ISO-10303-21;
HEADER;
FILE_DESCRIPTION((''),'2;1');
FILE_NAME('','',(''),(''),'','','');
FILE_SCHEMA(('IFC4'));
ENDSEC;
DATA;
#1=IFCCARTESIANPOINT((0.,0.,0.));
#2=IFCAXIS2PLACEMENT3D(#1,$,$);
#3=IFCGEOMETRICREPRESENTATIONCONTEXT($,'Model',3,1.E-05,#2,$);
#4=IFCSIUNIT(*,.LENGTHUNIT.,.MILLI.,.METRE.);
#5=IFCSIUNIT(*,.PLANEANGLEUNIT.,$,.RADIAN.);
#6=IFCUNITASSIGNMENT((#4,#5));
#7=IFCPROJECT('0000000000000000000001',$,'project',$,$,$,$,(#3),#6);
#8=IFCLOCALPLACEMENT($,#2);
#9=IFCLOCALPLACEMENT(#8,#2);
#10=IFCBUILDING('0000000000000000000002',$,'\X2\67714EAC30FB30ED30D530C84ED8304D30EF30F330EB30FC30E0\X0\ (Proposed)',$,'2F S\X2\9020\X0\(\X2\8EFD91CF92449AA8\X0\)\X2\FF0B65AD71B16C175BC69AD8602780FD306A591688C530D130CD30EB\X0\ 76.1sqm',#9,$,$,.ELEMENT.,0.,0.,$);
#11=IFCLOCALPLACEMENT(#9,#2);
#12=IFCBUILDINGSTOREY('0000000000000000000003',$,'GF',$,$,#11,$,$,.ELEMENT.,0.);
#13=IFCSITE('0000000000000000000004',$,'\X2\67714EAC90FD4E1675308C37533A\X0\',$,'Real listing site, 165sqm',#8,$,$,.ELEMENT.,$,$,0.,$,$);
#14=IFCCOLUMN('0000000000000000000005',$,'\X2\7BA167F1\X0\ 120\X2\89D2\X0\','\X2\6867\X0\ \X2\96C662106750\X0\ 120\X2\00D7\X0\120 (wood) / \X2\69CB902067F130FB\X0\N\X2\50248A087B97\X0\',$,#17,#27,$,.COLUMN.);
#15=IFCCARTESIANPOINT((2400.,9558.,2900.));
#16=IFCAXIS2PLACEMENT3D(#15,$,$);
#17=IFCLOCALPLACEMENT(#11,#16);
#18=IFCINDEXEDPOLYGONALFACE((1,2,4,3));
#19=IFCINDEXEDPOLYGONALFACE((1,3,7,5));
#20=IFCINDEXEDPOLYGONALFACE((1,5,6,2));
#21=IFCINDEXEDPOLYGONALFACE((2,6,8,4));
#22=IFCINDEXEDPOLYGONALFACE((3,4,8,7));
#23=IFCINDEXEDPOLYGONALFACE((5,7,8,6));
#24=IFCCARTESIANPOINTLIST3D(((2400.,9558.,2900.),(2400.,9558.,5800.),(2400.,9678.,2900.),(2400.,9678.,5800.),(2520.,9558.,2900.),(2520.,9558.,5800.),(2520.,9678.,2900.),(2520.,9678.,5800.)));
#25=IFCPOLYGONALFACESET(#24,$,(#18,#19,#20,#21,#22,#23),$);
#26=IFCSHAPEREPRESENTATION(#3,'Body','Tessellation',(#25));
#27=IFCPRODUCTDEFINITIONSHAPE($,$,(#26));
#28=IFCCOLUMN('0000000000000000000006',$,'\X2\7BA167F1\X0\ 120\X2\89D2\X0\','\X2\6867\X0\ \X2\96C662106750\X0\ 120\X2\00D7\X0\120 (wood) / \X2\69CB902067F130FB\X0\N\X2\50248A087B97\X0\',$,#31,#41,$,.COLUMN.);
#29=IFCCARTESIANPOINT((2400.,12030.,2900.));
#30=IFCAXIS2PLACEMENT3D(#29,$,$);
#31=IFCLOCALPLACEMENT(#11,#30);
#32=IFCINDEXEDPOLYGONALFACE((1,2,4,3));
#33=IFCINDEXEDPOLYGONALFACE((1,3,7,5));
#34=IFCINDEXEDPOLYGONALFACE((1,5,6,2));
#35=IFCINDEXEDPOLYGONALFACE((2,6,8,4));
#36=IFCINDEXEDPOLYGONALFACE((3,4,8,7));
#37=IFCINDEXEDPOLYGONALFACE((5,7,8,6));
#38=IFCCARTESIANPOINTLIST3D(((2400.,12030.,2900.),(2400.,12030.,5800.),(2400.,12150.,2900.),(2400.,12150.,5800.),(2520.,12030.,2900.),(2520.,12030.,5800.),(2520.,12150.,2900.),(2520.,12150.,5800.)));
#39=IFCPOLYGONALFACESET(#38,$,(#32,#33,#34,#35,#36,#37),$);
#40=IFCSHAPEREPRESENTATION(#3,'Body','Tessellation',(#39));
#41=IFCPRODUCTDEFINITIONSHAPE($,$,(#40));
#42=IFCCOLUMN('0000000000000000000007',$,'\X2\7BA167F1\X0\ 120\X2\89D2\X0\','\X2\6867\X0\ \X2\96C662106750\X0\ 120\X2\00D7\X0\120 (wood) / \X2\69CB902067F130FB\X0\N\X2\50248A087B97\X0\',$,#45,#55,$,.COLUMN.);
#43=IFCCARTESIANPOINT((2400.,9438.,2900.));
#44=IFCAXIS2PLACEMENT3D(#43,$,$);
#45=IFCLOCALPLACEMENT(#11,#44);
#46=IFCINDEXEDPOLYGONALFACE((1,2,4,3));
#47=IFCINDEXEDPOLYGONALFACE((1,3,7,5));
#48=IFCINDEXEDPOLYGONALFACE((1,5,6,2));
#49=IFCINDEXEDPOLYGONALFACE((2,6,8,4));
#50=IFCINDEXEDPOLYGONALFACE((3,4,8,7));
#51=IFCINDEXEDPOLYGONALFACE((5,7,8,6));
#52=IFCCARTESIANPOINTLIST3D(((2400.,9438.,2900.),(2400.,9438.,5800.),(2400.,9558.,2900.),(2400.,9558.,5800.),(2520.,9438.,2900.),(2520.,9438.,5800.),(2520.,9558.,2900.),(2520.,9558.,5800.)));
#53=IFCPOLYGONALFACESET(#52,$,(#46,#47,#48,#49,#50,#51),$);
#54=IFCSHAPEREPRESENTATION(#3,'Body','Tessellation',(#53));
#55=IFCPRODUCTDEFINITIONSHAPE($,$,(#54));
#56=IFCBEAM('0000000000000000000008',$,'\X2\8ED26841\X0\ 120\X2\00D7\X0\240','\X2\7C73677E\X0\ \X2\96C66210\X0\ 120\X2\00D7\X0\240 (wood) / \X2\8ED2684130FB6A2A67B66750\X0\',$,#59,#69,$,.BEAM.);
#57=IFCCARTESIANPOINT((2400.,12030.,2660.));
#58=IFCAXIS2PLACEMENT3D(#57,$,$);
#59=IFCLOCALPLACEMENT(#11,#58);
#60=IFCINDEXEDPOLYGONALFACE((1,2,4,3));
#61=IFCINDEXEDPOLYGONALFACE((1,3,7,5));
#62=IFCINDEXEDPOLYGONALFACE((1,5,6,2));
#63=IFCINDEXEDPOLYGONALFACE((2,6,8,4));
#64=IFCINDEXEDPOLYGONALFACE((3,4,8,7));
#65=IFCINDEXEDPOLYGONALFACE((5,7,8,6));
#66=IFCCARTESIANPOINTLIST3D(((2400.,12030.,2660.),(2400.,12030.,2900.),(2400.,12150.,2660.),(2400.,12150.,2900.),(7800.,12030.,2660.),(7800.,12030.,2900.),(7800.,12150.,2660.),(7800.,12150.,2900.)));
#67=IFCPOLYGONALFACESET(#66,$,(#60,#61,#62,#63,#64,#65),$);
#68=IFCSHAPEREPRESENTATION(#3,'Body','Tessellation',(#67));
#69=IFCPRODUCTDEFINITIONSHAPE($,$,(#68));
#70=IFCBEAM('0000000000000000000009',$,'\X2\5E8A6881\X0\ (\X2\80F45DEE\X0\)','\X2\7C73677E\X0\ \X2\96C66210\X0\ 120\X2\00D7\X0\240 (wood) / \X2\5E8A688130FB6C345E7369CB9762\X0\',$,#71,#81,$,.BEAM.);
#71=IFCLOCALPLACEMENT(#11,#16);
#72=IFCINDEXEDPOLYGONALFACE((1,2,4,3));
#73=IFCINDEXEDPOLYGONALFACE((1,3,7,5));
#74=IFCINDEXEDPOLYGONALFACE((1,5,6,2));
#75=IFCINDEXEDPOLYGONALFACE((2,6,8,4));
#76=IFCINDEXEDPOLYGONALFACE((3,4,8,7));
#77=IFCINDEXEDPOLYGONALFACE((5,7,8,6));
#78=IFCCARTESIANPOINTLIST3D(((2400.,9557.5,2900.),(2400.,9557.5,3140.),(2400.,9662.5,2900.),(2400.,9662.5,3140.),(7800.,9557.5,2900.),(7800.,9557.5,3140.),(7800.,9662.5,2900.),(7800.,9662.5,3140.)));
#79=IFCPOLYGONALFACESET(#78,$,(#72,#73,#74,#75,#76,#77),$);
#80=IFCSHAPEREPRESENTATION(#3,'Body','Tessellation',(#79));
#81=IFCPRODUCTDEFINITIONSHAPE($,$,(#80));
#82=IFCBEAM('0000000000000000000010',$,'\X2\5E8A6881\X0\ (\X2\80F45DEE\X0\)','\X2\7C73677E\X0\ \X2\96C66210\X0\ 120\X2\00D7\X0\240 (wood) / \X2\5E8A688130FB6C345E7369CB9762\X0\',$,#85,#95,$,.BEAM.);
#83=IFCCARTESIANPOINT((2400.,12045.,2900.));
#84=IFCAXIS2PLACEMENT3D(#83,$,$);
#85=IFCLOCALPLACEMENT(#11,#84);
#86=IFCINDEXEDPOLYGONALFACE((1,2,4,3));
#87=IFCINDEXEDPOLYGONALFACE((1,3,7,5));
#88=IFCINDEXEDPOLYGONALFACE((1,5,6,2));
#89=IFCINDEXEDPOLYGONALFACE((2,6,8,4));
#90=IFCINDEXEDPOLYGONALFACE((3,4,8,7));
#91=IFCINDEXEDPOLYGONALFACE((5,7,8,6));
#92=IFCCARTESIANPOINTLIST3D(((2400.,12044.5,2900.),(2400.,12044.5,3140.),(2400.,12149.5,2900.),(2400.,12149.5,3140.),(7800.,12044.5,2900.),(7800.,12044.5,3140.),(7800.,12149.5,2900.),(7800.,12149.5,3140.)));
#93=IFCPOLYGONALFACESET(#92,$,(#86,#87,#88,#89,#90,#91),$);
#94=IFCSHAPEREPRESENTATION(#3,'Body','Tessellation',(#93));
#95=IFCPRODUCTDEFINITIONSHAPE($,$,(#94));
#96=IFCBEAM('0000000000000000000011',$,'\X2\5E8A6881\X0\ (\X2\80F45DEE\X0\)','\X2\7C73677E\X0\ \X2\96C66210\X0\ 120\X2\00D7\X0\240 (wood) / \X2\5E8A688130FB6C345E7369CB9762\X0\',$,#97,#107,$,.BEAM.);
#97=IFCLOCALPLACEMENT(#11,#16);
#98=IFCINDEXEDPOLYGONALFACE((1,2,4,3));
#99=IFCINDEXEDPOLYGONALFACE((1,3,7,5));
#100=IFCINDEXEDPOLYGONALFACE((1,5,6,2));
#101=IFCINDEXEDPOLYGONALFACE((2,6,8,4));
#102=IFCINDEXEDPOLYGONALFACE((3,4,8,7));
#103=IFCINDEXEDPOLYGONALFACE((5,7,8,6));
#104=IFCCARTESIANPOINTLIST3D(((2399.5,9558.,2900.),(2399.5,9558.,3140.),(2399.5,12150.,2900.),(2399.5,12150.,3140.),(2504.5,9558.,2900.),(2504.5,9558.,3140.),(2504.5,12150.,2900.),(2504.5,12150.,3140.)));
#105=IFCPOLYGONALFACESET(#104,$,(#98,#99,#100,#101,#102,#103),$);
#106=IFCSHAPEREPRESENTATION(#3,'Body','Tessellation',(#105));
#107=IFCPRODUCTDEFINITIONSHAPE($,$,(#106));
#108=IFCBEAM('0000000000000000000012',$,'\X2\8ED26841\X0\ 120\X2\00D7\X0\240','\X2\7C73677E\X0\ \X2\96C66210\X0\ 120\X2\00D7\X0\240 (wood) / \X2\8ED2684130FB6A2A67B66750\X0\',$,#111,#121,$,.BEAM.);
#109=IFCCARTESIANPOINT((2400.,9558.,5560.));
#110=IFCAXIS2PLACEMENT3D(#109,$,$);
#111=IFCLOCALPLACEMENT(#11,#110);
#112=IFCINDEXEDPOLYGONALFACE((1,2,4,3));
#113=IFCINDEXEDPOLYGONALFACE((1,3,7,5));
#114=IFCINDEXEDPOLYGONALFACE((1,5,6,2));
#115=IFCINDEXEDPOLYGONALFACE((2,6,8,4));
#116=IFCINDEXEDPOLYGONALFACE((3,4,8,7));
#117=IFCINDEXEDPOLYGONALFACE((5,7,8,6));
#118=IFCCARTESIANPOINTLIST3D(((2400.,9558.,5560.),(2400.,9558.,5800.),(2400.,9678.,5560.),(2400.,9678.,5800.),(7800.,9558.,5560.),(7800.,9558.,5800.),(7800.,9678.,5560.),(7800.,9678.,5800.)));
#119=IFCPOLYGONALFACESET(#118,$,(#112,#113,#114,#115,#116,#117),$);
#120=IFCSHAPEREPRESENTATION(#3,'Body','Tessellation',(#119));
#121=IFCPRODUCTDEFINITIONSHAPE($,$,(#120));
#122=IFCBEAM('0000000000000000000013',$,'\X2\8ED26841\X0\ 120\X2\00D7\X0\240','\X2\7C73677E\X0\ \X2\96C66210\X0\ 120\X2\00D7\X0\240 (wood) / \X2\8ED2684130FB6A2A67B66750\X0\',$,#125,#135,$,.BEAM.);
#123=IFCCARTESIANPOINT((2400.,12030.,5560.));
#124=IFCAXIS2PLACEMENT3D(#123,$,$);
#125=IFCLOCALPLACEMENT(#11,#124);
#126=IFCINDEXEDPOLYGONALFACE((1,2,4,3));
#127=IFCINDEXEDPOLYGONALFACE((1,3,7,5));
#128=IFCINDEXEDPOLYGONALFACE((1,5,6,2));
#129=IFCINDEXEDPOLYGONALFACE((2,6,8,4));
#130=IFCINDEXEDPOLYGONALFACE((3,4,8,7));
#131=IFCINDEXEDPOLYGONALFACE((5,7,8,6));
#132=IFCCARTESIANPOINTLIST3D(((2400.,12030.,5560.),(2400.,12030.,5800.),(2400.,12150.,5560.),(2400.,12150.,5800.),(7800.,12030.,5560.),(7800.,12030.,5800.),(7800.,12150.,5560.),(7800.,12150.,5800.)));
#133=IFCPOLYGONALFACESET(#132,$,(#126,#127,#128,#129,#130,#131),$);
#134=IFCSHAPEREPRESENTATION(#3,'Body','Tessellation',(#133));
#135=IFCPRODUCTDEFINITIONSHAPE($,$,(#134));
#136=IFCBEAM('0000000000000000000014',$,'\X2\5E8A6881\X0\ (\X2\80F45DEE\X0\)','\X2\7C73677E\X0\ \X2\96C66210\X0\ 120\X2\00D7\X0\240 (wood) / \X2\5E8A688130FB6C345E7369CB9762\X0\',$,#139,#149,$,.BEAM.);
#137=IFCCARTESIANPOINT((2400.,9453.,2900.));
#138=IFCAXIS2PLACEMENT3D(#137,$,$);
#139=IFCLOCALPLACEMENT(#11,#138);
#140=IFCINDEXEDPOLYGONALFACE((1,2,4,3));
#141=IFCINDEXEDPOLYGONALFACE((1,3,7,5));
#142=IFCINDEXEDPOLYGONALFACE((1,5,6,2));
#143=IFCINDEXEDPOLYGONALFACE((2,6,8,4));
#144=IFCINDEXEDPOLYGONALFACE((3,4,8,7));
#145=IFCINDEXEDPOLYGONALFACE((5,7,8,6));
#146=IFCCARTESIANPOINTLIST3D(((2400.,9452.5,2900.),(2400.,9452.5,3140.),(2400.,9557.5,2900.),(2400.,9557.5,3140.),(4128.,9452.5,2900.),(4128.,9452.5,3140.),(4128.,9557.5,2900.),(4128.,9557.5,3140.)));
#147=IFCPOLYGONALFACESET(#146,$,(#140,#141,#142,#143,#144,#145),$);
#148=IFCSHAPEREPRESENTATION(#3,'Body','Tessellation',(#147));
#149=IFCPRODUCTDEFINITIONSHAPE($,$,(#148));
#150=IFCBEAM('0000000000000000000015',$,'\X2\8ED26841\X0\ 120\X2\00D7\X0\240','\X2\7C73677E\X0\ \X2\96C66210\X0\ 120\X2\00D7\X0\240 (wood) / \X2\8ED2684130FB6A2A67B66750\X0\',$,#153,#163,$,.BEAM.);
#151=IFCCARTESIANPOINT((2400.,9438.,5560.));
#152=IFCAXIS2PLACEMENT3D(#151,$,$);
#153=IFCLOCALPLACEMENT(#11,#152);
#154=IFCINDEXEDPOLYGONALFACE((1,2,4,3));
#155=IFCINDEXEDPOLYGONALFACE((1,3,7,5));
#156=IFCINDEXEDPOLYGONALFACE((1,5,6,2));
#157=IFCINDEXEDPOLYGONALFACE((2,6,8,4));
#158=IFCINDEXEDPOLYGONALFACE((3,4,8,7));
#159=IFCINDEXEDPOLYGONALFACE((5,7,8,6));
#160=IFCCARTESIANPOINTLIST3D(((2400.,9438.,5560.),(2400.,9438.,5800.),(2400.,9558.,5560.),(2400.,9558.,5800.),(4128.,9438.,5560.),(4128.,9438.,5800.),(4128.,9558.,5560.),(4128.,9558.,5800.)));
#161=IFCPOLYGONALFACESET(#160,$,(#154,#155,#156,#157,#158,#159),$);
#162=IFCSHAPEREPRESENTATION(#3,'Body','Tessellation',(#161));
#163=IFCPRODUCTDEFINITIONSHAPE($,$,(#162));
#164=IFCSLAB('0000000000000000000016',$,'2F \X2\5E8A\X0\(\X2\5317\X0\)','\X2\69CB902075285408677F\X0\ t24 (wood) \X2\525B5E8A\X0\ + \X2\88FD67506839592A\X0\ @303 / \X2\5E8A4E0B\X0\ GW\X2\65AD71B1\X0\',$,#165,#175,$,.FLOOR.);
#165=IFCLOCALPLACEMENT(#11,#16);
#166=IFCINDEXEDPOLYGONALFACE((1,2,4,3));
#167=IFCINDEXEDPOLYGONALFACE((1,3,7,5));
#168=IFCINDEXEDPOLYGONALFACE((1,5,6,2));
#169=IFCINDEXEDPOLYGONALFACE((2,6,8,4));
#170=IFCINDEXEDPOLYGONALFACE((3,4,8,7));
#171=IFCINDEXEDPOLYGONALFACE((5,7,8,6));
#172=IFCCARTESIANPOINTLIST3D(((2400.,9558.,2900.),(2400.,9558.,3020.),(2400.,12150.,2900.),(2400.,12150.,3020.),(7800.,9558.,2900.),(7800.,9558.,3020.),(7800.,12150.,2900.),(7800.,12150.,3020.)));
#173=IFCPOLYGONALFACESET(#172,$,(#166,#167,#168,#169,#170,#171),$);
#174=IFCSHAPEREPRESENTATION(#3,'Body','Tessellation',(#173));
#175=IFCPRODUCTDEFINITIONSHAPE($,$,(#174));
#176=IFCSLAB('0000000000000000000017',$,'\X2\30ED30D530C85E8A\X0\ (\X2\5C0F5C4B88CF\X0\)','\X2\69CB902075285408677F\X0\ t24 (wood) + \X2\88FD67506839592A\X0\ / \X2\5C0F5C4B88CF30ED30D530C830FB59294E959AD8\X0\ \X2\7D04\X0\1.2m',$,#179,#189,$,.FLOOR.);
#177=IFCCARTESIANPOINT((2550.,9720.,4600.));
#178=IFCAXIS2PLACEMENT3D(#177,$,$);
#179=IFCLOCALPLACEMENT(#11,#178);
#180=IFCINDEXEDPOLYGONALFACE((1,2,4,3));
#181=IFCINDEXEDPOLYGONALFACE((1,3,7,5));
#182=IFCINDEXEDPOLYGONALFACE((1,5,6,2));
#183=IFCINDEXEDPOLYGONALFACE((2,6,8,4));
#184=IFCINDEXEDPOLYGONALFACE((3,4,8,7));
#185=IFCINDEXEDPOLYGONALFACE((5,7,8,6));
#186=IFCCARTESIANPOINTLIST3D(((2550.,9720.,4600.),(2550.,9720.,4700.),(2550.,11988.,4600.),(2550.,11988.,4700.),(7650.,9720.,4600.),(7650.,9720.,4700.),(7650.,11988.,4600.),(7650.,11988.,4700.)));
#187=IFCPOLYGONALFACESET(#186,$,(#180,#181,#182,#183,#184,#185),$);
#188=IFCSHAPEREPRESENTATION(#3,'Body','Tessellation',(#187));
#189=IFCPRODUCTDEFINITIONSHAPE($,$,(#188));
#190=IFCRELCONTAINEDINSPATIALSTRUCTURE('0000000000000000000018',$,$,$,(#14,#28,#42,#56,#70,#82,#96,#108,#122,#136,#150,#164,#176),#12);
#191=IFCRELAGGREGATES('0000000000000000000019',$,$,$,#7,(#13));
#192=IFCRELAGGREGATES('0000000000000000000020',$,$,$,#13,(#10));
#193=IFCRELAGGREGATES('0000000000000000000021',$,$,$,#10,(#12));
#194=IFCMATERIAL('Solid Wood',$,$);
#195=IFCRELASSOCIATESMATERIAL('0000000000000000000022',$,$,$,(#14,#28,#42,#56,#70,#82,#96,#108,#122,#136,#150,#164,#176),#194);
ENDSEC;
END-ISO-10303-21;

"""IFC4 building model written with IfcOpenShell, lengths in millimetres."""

from ifc_helpers import new_model, si_unit, frame, frame_2d, origin, place, context, project, spatial, rectangle, extrude, material, element, save


model = new_model("IFC4")

# Units and contexts
model_context = context("Model", 3, precision=1e-05, world=origin())
ifc_project = project(units=[si_unit("LENGTHUNIT", "METRE", prefix="MILLI"), si_unit("PLANEANGLEUNIT", "RADIAN")], contexts=[model_context])

# Site, building, storey
site_placement = place(None, origin())
site = spatial("IfcSite", under=ifc_project, at=site_placement, Name="東京都世田谷区", ObjectType="Real listing site, 165sqm", CompositionType="ELEMENT", RefElevation=0.0)
building_placement = place(site_placement, origin())
building = spatial("IfcBuilding", under=site, at=building_placement, Name="東京・ロフト付きワンルーム (Proposed)", ObjectType="2F S造(軽量鉄骨)＋断熱気密高性能な外装パネル 76.1sqm", CompositionType="ELEMENT", ElevationOfRefHeight=0.0, ElevationOfTerrain=0.0)
storey_placement = place(building_placement, origin())
storey = spatial("IfcBuildingStorey", under=building, at=storey_placement, Name="GF", CompositionType="ELEMENT", Elevation=0.0)

# Columns
ifc_material_1 = material(Name="Solid Wood")
column_1_placement = place(storey_placement, frame((2400.0, 9558.0, 2900.0)))
element("IfcColumn", 1, at=column_1_placement, inside=storey, material=ifc_material_1, Name="管柱 120角", Description="桧 集成材 120×120 (wood) / 構造柱・N値計算", PredefinedType="COLUMN", context=model_context, shape_type="SweptSolid", body=[
    extrude(rectangle(XDim=120.0, YDim=120.0, at=frame_2d((60.0, 60.0))), frame((2400.0, 9558.0, 2900.0)), (0.0, 0.0, 1.0), 2900.0),
])
column_2_placement = place(storey_placement, frame((2400.0, 12030.0, 2900.0)))
element("IfcColumn", 2, at=column_2_placement, inside=storey, material=ifc_material_1, Name="管柱 120角", Description="桧 集成材 120×120 (wood) / 構造柱・N値計算", PredefinedType="COLUMN", context=model_context, shape_type="SweptSolid", body=[
    extrude(rectangle(XDim=120.0, YDim=120.0, at=frame_2d((60.0, 60.0))), frame((2400.0, 12030.0, 2900.0)), (0.0, 0.0, 1.0), 2900.0),
])
column_3_placement = place(storey_placement, frame((2400.0, 9438.0, 2900.0)))
element("IfcColumn", 3, at=column_3_placement, inside=storey, material=ifc_material_1, Name="管柱 120角", Description="桧 集成材 120×120 (wood) / 構造柱・N値計算", PredefinedType="COLUMN", context=model_context, shape_type="SweptSolid", body=[
    extrude(rectangle(XDim=120.0, YDim=120.0, at=frame_2d((60.0, 60.0))), frame((2400.0, 9438.0, 2900.0)), (0.0, 0.0, 1.0), 2900.0),
])

# Beams
beam_1_placement = place(storey_placement, frame((2400.0, 12030.0, 2660.0)))
element("IfcBeam", 4, at=beam_1_placement, inside=storey, material=ifc_material_1, Name="軒桁 120×240", Description="米松 集成 120×240 (wood) / 軒桁・横架材", PredefinedType="BEAM", context=model_context, shape_type="SweptSolid", body=[
    extrude(rectangle(XDim=5400.0, YDim=120.0, at=frame_2d((2700.0, 60.0))), frame((2400.0, 12030.0, 2660.0)), (0.0, 0.0, 1.0), 240.0),
])
beam_2_placement = place(storey_placement, frame((2400.0, 9558.0, 2900.0)))
element("IfcBeam", 5, at=beam_2_placement, inside=storey, material=ifc_material_1, Name="床梁 (胴差)", Description="米松 集成 120×240 (wood) / 床梁・水平構面", PredefinedType="BEAM", context=model_context, shape_type="SweptSolid", body=[
    extrude(rectangle(XDim=5400.0, YDim=105.0, at=frame_2d((2700.0, 52.0))), frame((2400.0, 9558.0, 2900.0)), (0.0, 0.0, 1.0), 240.0),
])
beam_3_placement = place(storey_placement, frame((2400.0, 12045.0, 2900.0)))
element("IfcBeam", 6, at=beam_3_placement, inside=storey, material=ifc_material_1, Name="床梁 (胴差)", Description="米松 集成 120×240 (wood) / 床梁・水平構面", PredefinedType="BEAM", context=model_context, shape_type="SweptSolid", body=[
    extrude(rectangle(XDim=5400.0, YDim=105.0, at=frame_2d((2700.0, 52.0))), frame((2400.0, 12045.0, 2900.0)), (0.0, 0.0, 1.0), 240.0),
])
beam_4_placement = place(storey_placement, frame((2400.0, 9558.0, 2900.0)))
element("IfcBeam", 7, at=beam_4_placement, inside=storey, material=ifc_material_1, Name="床梁 (胴差)", Description="米松 集成 120×240 (wood) / 床梁・水平構面", PredefinedType="BEAM", context=model_context, shape_type="SweptSolid", body=[
    extrude(rectangle(XDim=105.0, YDim=2592.0, at=frame_2d((52.0, 1296.0))), frame((2400.0, 9558.0, 2900.0)), (0.0, 0.0, 1.0), 240.0),
])
beam_5_placement = place(storey_placement, frame((2400.0, 9558.0, 5560.0)))
element("IfcBeam", 8, at=beam_5_placement, inside=storey, material=ifc_material_1, Name="軒桁 120×240", Description="米松 集成 120×240 (wood) / 軒桁・横架材", PredefinedType="BEAM", context=model_context, shape_type="SweptSolid", body=[
    extrude(rectangle(XDim=5400.0, YDim=120.0, at=frame_2d((2700.0, 60.0))), frame((2400.0, 9558.0, 5560.0)), (0.0, 0.0, 1.0), 240.0),
])
beam_6_placement = place(storey_placement, frame((2400.0, 12030.0, 5560.0)))
element("IfcBeam", 9, at=beam_6_placement, inside=storey, material=ifc_material_1, Name="軒桁 120×240", Description="米松 集成 120×240 (wood) / 軒桁・横架材", PredefinedType="BEAM", context=model_context, shape_type="SweptSolid", body=[
    extrude(rectangle(XDim=5400.0, YDim=120.0, at=frame_2d((2700.0, 60.0))), frame((2400.0, 12030.0, 5560.0)), (0.0, 0.0, 1.0), 240.0),
])
beam_7_placement = place(storey_placement, frame((2400.0, 9453.0, 2900.0)))
element("IfcBeam", 10, at=beam_7_placement, inside=storey, material=ifc_material_1, Name="床梁 (胴差)", Description="米松 集成 120×240 (wood) / 床梁・水平構面", PredefinedType="BEAM", context=model_context, shape_type="SweptSolid", body=[
    extrude(rectangle(XDim=1728.0, YDim=105.0, at=frame_2d((864.0, 52.0))), frame((2400.0, 9453.0, 2900.0)), (0.0, 0.0, 1.0), 240.0),
])
beam_8_placement = place(storey_placement, frame((2400.0, 9438.0, 5560.0)))
element("IfcBeam", 11, at=beam_8_placement, inside=storey, material=ifc_material_1, Name="軒桁 120×240", Description="米松 集成 120×240 (wood) / 軒桁・横架材", PredefinedType="BEAM", context=model_context, shape_type="SweptSolid", body=[
    extrude(rectangle(XDim=1728.0, YDim=120.0, at=frame_2d((864.0, 60.0))), frame((2400.0, 9438.0, 5560.0)), (0.0, 0.0, 1.0), 240.0),
])

# Slabs
slab_1_placement = place(storey_placement, frame((2400.0, 9558.0, 2900.0)))
element("IfcSlab", 12, at=slab_1_placement, inside=storey, material=ifc_material_1, Name="2F 床(北)", Description="構造用合板 t24 (wood) 剛床 + 製材根太 @303 / 床下 GW断熱", PredefinedType="FLOOR", context=model_context, shape_type="SweptSolid", body=[
    extrude(rectangle(XDim=5400.0, YDim=2592.0, at=frame_2d((2700.0, 1296.0))), frame((2400.0, 9558.0, 2900.0)), (0.0, 0.0, 1.0), 120.0),
])
slab_2_placement = place(storey_placement, frame((2550.0, 9720.0, 4600.0)))
element("IfcSlab", 13, at=slab_2_placement, inside=storey, material=ifc_material_1, Name="ロフト床 (小屋裏)", Description="構造用合板 t24 (wood) + 製材根太 / 小屋裏ロフト・天井高 約1.2m", PredefinedType="FLOOR", context=model_context, shape_type="SweptSolid", body=[
    extrude(rectangle(XDim=5100.0, YDim=2268.0, at=frame_2d((2550.0, 1134.0))), frame((2550.0, 9720.0, 4600.0)), (0.0, 0.0, 1.0), 100.0),
])

save(model, "model.ifc")
